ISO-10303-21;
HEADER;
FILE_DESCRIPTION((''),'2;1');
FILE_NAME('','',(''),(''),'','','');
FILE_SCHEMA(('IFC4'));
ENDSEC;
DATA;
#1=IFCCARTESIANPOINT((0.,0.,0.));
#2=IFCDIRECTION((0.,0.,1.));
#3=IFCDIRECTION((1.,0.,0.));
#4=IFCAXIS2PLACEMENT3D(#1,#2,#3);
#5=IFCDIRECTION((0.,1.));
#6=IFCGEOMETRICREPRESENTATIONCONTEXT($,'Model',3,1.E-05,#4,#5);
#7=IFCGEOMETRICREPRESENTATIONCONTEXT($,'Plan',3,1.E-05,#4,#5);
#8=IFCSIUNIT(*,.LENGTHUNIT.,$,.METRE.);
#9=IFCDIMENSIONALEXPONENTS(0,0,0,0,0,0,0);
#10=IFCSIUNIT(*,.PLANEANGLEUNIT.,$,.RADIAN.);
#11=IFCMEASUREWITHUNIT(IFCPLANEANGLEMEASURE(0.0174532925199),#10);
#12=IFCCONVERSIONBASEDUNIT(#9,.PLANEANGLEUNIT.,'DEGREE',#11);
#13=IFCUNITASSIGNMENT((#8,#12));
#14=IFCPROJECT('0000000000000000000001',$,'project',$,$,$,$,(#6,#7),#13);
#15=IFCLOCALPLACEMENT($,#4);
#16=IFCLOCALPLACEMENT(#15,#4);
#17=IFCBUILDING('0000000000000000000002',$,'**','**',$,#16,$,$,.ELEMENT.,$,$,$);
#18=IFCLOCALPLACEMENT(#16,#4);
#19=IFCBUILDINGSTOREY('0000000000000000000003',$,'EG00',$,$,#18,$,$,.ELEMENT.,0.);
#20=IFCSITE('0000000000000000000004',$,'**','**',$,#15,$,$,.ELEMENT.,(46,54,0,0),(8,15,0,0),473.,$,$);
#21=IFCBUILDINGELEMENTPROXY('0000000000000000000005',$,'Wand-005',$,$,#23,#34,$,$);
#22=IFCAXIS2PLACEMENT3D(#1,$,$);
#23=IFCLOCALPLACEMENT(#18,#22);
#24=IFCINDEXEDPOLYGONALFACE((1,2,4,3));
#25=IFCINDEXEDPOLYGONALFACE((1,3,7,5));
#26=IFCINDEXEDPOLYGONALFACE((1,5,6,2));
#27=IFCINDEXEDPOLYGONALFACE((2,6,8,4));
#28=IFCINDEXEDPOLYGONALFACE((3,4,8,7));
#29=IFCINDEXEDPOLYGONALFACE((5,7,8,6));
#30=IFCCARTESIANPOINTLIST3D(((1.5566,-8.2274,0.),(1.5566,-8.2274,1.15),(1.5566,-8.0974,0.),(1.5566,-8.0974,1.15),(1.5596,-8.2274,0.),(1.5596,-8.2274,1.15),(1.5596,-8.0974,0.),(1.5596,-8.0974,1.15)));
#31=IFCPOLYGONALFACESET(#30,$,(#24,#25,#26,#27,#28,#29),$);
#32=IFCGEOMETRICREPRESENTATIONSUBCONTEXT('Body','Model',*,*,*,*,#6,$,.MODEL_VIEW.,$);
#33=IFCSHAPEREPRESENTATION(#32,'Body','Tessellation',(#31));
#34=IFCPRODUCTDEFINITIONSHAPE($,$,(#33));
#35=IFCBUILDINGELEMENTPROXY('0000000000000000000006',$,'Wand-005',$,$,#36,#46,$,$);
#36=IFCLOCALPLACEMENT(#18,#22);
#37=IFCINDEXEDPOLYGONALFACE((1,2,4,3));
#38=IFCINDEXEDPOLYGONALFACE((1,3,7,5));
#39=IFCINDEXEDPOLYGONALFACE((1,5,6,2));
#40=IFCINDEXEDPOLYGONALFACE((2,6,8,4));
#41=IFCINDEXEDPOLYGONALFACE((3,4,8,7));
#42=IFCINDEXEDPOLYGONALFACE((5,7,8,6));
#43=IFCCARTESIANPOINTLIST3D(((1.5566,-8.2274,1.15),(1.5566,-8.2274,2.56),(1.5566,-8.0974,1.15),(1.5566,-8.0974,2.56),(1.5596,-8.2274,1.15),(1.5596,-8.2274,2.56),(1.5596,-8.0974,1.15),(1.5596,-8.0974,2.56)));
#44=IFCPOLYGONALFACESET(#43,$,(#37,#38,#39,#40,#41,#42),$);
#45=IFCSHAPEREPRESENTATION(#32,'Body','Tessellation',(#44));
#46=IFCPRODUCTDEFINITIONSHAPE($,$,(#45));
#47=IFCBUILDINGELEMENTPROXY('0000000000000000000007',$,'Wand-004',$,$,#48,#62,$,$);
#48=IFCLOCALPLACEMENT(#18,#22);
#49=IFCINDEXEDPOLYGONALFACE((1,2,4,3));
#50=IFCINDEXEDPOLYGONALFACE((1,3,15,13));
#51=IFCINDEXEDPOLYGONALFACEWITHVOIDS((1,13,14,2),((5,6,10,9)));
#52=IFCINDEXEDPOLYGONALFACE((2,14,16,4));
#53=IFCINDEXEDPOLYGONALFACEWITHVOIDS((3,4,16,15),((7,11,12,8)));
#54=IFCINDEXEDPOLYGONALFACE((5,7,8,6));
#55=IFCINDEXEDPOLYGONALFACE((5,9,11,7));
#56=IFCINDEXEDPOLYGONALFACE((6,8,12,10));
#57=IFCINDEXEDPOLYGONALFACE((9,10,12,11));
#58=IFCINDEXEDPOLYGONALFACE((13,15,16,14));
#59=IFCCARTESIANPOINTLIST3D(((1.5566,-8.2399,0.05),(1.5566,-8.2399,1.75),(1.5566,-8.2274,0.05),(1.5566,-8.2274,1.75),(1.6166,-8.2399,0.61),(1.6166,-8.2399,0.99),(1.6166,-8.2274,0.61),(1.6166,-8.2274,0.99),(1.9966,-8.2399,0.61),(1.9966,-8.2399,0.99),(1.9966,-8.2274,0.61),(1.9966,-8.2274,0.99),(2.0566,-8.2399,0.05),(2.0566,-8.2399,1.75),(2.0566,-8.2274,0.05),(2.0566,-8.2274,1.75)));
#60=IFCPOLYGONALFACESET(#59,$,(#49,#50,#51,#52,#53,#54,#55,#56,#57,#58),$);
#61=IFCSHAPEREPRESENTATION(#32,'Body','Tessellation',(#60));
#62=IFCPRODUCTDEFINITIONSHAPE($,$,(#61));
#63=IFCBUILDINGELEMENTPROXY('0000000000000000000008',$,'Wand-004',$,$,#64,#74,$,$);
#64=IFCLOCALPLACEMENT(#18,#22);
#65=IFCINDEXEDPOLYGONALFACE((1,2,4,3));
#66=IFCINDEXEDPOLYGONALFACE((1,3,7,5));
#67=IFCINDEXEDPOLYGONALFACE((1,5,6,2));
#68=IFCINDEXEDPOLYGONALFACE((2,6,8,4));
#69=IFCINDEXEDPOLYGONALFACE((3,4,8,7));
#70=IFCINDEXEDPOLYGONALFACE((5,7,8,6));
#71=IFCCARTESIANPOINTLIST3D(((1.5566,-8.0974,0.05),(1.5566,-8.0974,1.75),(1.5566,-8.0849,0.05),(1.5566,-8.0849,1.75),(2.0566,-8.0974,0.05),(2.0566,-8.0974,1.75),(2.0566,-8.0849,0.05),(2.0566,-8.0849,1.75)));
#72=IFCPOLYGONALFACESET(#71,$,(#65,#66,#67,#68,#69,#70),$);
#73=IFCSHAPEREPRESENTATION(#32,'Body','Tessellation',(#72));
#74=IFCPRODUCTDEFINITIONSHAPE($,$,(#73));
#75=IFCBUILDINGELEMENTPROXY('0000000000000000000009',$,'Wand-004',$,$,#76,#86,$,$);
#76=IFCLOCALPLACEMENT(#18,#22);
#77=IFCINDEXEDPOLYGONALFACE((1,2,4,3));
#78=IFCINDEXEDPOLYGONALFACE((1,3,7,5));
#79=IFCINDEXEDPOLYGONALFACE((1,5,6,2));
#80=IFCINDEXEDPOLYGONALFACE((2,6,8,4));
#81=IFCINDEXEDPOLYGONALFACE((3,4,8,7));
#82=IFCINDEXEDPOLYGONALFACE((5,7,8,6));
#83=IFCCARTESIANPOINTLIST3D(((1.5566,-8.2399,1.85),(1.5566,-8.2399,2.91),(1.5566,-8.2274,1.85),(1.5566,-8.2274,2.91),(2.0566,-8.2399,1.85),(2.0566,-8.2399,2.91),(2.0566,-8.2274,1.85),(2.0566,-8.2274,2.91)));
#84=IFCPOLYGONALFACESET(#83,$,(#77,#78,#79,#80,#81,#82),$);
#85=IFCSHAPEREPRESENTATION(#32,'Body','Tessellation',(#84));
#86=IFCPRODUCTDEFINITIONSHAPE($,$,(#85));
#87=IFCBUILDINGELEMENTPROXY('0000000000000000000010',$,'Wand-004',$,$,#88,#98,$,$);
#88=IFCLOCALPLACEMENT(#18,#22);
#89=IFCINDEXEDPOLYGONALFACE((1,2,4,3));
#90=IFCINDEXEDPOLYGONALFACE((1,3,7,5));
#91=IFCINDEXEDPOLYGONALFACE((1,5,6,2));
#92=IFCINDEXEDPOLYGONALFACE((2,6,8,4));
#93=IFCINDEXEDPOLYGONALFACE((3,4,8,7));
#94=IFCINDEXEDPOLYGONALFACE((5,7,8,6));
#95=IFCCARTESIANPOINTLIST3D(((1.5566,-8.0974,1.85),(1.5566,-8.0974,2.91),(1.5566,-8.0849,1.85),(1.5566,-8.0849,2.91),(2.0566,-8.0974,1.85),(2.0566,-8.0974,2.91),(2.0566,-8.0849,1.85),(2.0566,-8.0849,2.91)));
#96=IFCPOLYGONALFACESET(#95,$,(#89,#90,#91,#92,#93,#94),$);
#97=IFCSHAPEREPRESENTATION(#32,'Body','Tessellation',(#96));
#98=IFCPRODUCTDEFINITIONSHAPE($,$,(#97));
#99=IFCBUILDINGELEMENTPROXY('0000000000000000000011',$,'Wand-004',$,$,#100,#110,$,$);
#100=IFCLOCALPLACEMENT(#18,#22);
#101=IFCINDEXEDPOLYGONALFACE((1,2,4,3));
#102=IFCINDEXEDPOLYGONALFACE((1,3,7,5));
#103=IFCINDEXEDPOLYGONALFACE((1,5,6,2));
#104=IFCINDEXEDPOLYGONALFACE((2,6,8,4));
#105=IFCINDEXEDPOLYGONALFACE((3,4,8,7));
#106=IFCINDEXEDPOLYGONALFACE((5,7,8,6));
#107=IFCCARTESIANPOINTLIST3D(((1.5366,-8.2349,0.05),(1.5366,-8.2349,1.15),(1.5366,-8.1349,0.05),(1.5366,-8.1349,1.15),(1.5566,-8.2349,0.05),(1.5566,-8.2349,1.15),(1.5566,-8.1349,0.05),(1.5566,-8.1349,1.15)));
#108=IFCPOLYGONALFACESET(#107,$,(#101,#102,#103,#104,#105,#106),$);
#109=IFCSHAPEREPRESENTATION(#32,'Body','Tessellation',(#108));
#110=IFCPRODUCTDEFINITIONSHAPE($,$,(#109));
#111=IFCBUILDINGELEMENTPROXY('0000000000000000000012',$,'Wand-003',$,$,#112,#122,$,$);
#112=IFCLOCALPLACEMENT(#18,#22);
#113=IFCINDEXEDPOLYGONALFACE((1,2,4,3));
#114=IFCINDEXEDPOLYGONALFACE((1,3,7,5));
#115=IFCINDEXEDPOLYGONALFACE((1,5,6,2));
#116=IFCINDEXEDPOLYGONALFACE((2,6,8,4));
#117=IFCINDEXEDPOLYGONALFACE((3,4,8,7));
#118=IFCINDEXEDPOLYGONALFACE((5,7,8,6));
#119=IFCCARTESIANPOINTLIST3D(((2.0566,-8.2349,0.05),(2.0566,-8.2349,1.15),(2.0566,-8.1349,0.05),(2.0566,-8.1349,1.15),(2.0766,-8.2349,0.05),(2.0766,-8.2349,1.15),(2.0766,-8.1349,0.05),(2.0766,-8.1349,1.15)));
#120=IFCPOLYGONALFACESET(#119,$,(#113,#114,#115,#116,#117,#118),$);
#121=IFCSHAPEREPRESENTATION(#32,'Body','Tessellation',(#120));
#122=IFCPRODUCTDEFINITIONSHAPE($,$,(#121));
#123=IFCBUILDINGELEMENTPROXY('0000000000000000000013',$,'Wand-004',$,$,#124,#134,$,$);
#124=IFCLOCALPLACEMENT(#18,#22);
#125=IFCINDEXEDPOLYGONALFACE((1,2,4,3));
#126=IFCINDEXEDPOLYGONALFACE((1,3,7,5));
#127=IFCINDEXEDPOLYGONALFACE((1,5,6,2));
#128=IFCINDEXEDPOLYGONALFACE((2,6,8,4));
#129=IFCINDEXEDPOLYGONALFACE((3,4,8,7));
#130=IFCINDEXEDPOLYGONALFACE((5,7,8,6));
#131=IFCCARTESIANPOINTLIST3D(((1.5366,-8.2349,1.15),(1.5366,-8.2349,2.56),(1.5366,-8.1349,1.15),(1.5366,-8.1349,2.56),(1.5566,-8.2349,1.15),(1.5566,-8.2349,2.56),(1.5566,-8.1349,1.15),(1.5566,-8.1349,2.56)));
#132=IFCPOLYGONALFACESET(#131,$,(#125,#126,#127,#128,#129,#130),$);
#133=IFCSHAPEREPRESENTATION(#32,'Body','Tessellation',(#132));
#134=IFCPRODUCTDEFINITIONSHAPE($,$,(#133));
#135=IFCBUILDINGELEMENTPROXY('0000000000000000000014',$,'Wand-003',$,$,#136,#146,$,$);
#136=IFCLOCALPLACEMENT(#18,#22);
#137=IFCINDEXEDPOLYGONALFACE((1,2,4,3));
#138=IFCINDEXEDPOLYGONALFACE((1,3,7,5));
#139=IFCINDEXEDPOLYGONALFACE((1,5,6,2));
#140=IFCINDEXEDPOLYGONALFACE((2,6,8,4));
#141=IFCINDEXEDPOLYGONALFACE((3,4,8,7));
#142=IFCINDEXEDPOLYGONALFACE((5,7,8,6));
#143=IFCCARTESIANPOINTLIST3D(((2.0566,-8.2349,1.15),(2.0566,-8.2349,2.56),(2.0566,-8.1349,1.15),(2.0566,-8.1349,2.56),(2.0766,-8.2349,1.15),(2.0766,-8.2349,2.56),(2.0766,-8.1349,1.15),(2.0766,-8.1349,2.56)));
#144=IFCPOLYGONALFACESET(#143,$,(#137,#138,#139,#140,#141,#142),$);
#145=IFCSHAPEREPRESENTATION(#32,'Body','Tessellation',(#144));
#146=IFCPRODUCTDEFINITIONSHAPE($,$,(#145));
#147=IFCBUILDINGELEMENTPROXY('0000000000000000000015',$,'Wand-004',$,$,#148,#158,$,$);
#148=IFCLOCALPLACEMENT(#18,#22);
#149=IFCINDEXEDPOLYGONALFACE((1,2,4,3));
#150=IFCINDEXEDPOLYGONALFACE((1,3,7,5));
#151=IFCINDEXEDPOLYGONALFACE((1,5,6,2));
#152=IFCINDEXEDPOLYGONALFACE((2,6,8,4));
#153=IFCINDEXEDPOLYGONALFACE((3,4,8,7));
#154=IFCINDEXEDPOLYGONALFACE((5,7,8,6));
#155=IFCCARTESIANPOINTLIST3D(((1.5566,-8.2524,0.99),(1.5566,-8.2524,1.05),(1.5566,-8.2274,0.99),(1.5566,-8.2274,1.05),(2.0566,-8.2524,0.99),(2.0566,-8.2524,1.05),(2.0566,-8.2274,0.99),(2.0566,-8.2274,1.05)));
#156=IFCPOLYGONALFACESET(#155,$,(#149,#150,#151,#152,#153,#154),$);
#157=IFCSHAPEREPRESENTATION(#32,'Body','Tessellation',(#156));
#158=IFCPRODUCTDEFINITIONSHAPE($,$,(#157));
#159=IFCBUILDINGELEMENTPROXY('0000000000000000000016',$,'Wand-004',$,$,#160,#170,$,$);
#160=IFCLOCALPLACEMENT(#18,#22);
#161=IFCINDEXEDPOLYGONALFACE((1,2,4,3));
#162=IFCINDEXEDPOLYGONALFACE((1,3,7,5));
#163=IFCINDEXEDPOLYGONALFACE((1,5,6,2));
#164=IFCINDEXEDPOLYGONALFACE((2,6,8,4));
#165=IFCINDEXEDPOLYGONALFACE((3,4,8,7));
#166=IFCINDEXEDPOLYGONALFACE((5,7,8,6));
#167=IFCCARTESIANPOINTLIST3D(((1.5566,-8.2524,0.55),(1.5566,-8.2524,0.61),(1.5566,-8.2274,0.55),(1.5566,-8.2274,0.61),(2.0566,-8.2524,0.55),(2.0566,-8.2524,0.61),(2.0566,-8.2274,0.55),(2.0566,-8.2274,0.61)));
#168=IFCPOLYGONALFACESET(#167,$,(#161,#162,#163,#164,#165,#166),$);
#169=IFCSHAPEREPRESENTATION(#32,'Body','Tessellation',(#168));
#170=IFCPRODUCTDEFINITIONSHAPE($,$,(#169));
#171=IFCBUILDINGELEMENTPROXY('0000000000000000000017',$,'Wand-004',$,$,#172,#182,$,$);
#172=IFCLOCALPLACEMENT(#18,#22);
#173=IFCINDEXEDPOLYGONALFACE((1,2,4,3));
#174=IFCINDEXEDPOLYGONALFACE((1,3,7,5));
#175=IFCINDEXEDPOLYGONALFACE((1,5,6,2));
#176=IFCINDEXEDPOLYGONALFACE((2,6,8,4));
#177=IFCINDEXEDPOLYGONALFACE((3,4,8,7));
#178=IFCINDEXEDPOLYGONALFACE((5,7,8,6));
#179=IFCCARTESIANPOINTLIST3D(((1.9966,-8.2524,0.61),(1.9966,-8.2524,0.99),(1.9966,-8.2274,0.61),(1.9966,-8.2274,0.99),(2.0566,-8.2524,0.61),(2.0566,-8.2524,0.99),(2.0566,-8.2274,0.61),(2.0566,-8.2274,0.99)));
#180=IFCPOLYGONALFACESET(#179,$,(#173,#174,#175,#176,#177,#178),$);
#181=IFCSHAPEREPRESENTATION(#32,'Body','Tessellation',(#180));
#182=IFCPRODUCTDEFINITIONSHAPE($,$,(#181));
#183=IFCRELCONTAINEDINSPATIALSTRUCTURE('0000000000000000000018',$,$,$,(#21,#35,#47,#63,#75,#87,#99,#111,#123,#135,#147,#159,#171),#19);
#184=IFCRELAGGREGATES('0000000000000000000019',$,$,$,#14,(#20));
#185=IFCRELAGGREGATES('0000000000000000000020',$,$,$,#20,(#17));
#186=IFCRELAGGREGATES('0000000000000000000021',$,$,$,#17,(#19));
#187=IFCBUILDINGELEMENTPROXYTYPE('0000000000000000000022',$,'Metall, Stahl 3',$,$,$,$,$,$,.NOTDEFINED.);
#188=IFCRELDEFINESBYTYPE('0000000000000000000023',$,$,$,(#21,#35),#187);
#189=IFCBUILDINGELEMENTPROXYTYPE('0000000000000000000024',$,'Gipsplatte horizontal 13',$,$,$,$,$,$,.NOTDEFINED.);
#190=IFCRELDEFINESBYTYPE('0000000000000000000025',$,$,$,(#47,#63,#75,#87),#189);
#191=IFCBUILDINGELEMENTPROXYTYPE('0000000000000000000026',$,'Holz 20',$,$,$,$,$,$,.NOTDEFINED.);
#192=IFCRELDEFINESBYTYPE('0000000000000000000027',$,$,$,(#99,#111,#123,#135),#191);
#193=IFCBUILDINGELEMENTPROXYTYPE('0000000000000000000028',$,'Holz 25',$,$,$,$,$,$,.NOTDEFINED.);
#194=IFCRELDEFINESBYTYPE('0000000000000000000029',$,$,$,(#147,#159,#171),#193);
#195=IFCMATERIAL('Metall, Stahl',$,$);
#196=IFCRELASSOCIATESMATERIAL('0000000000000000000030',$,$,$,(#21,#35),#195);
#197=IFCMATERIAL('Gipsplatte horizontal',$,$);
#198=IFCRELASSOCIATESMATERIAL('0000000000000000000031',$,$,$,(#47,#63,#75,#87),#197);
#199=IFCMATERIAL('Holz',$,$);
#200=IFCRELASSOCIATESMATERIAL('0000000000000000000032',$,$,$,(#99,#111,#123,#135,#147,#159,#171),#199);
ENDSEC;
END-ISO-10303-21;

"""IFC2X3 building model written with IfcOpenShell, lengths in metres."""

from ifc_helpers import new_model, entity, si_unit, converted_unit, direction, frame, origin_with_axes, origin_2d_with_axis, place, context, subcontext, project, spatial, polyline, rectangle, outline, extrude, material, type_object, element, save


model = new_model("IFC2X3")

# Units and contexts
model_context = context("Model", 3, precision=1e-05, world=origin_with_axes(), true_north=direction((0.0, 1.0)))
plan_context = context("Plan", 3, precision=1e-05, world=origin_with_axes(), true_north=direction((0.0, 1.0)))
body_context = subcontext(model_context, "Body", "Model", "MODEL_VIEW")
ifc_project = project(units=[si_unit("LENGTHUNIT", "METRE"), converted_unit("PLANEANGLEUNIT", "DEGREE", entity("IfcPlaneAngleMeasure", 0.0174532925199), si_unit("PLANEANGLEUNIT", "RADIAN"), dimensions=[0, 0, 0, 0, 0, 0, 0])], contexts=[model_context, plan_context])

# Site, building, storey
site_placement = place(None, origin_with_axes())
site = spatial("IfcSite", under=ifc_project, at=site_placement, Name="**", Description="**", CompositionType="ELEMENT", RefLatitude=(46, 54, 0, 0), RefLongitude=(8, 15, 0, 0), RefElevation=473.0)
building_placement = place(site_placement, origin_with_axes())
building = spatial("IfcBuilding", under=site, at=building_placement, Name="**", Description="**", CompositionType="ELEMENT")
storey_placement = place(building_placement, origin_with_axes())
storey = spatial("IfcBuildingStorey", under=building, at=storey_placement, Name="EG00", CompositionType="ELEMENT", Elevation=0.0)

# Building element proxies
ifc_material_1 = material(Name="Metall, Stahl")
building_element_proxy_type_1 = type_object("IfcBuildingElementProxyType", Name="Metall, Stahl 3", PredefinedType="NOTDEFINED")
proxy_1_placement = place(storey_placement, frame((1.5566, -8.0974, 0.0), z_axis=(0.0, 0.0, 1.0), x_axis=(0.0, -1.0, 0.0)))
element("IfcBuildingElementProxy", 1, at=proxy_1_placement, inside=storey, type_object=building_element_proxy_type_1, material=ifc_material_1, Name="Wand-005", context=body_context, shape_type="SweptSolid", body=[
    extrude(outline(polyline([(0.0, 0.0), (0.13, 0.0), (0.13, 0.003), (0.0, 0.003), (0.0, 0.0)])), origin_with_axes(), (0.0, 0.0, 1.0), 1.15),
])
proxy_2_placement = place(storey_placement, frame((1.5566, -8.0974, 1.15), z_axis=(0.0, 0.0, 1.0), x_axis=(0.0, -1.0, 0.0)))
element("IfcBuildingElementProxy", 2, at=proxy_2_placement, inside=storey, type_object=building_element_proxy_type_1, material=ifc_material_1, Name="Wand-005", context=body_context, shape_type="SweptSolid", body=[
    extrude(outline(polyline([(0.0, 0.0), (0.13, 0.0), (0.13, 0.003), (0.0, 0.003), (0.0, 0.0)])), origin_with_axes(), (0.0, 0.0, 1.0), 1.41),
])

# Building element proxy, opening
ifc_material_2 = material(Name="Gipsplatte horizontal")
building_element_proxy_type_2 = type_object("IfcBuildingElementProxyType", Name="Gipsplatte horizontal 13", PredefinedType="NOTDEFINED")
proxy_3_placement = place(storey_placement, frame((1.5566, -8.2399, 0.05), z_axis=(0.0, 0.0, 1.0), x_axis=(1.0, 0.0, 0.0)))
proxy_3 = element("IfcBuildingElementProxy", 3, at=proxy_3_placement, inside=storey, type_object=building_element_proxy_type_2, material=ifc_material_2, Name="Wand-004", context=body_context, shape_type="SweptSolid", body=[
    extrude(outline(polyline([(0.0, 0.0), (0.5, 0.0), (0.5, 0.0125), (0.0, 0.0125), (0.0, 0.0)])), origin_with_axes(), (0.0, 0.0, 1.0), 1.7),
])
opening_placement = place(proxy_3_placement, frame((-1.5566, 8.2399, -0.05), z_axis=(0.0, 0.0, 1.0), x_axis=(1.0, 0.0, 0.0)))
element("IfcOpeningElement", 4, at=opening_placement, cuts=proxy_3, context=body_context, shape_type="SweptSolid", body=[
    extrude(rectangle(XDim=0.38, YDim=0.38, at=origin_2d_with_axis()), frame((1.8066, -8.2524, 0.8), z_axis=(0.0, -1.0, 0.0), x_axis=(1.0, 0.0, 0.0)), (0.0, 0.0, -1.0), 0.0375),
])

# Building element proxies
proxy_4_placement = place(storey_placement, frame((1.5566, -8.0849, 0.05), z_axis=(0.0, 0.0, 1.0), x_axis=(1.0, 0.0, 0.0)))
element("IfcBuildingElementProxy", 5, at=proxy_4_placement, inside=storey, type_object=building_element_proxy_type_2, material=ifc_material_2, Name="Wand-004", context=body_context, shape_type="SweptSolid", body=[
    extrude(outline(polyline([(0.0, -0.0125), (0.5, -0.0125), (0.5, 0.0), (0.0, 0.0), (0.0, -0.0125)])), origin_with_axes(), (0.0, 0.0, 1.0), 1.7),
])
proxy_5_placement = place(storey_placement, frame((1.5566, -8.2399, 1.85), z_axis=(0.0, 0.0, 1.0), x_axis=(1.0, 0.0, 0.0)))
element("IfcBuildingElementProxy", 6, at=proxy_5_placement, inside=storey, type_object=building_element_proxy_type_2, material=ifc_material_2, Name="Wand-004", context=body_context, shape_type="SweptSolid", body=[
    extrude(outline(polyline([(0.0, 0.0), (0.5, 0.0), (0.5, 0.0125), (0.0, 0.0125), (0.0, 0.0)])), origin_with_axes(), (0.0, 0.0, 1.0), 1.06),
])
proxy_6_placement = place(storey_placement, frame((1.5566, -8.0849, 1.85), z_axis=(0.0, 0.0, 1.0), x_axis=(1.0, 0.0, 0.0)))
element("IfcBuildingElementProxy", 7, at=proxy_6_placement, inside=storey, type_object=building_element_proxy_type_2, material=ifc_material_2, Name="Wand-004", context=body_context, shape_type="SweptSolid", body=[
    extrude(outline(polyline([(0.0, -0.0125), (0.5, -0.0125), (0.5, 0.0), (0.0, 0.0), (0.0, -0.0125)])), origin_with_axes(), (0.0, 0.0, 1.0), 1.06),
])
ifc_material_3 = material(Name="Holz")
building_element_proxy_type_3 = type_object("IfcBuildingElementProxyType", Name="Holz 20", PredefinedType="NOTDEFINED")
proxy_7_placement = place(storey_placement, frame((1.5366, -8.1349, 0.05), z_axis=(0.0, 0.0, 1.0), x_axis=(0.0, -1.0, 0.0)))
element("IfcBuildingElementProxy", 8, at=proxy_7_placement, inside=storey, type_object=building_element_proxy_type_3, material=ifc_material_3, Name="Wand-004", context=body_context, shape_type="SweptSolid", body=[
    extrude(outline(polyline([(0.0, 0.0), (0.1, 0.0), (0.1, 0.02), (0.0, 0.02), (0.0, 0.0)])), origin_with_axes(), (0.0, 0.0, 1.0), 1.1),
])
proxy_8_placement = place(storey_placement, frame((2.0766, -8.1349, 0.05), z_axis=(0.0, 0.0, 1.0), x_axis=(0.0, -1.0, 0.0)))
element("IfcBuildingElementProxy", 9, at=proxy_8_placement, inside=storey, type_object=building_element_proxy_type_3, material=ifc_material_3, Name="Wand-003", context=body_context, shape_type="SweptSolid", body=[
    extrude(outline(polyline([(0.0, -0.02), (0.1, -0.02), (0.1, 0.0), (0.0, 0.0), (0.0, -0.02)])), origin_with_axes(), (0.0, 0.0, 1.0), 1.1),
])
proxy_9_placement = place(storey_placement, frame((1.5366, -8.1349, 1.15), z_axis=(0.0, 0.0, 1.0), x_axis=(0.0, -1.0, 0.0)))
element("IfcBuildingElementProxy", 10, at=proxy_9_placement, inside=storey, type_object=building_element_proxy_type_3, material=ifc_material_3, Name="Wand-004", context=body_context, shape_type="SweptSolid", body=[
    extrude(outline(polyline([(0.0, 0.0), (0.1, 0.0), (0.1, 0.02), (0.0, 0.02), (0.0, 0.0)])), origin_with_axes(), (0.0, 0.0, 1.0), 1.41),
])
proxy_10_placement = place(storey_placement, frame((2.0766, -8.1349, 1.15), z_axis=(0.0, 0.0, 1.0), x_axis=(0.0, -1.0, 0.0)))
element("IfcBuildingElementProxy", 11, at=proxy_10_placement, inside=storey, type_object=building_element_proxy_type_3, material=ifc_material_3, Name="Wand-003", context=body_context, shape_type="SweptSolid", body=[
    extrude(outline(polyline([(0.0, -0.02), (0.1, -0.02), (0.1, 0.0), (0.0, 0.0), (0.0, -0.02)])), origin_with_axes(), (0.0, 0.0, 1.0), 1.41),
])
building_element_proxy_type_4 = type_object("IfcBuildingElementProxyType", Name="Holz 25", PredefinedType="NOTDEFINED")
for number, where, z_axis, x_axis, name in (
    (12, (2.0566, -8.2274, 0.99), (0.0, 0.0, 1.0), (-1.0, 0.0, 0.0), "Wand-004"),
    (13, (2.0566, -8.2274, 0.55), (0.0, 0.0, 1.0), (-1.0, 0.0, 0.0), "Wand-004"),
):
    element("IfcBuildingElementProxy", number, at=place(storey_placement, frame(where, z_axis=z_axis, x_axis=x_axis)), inside=storey, type_object=building_element_proxy_type_4, material=ifc_material_3, Name=name, context=body_context, shape_type="SweptSolid", body=[
        extrude(outline(polyline([(0.0, 0.0), (0.5, 0.0), (0.5, 0.025), (0.0, 0.025), (0.0, 0.0)])), origin_with_axes(), (0.0, 0.0, 1.0), 0.06),
    ])
for number, where, z_axis, x_axis, name in (
    (14, (1.9966, -8.2524, 0.61), (0.0, 0.0, 1.0), (1.0, 0.0, 0.0), "Wand-004"),
):
    element("IfcBuildingElementProxy", number, at=place(storey_placement, frame(where, z_axis=z_axis, x_axis=x_axis)), inside=storey, type_object=building_element_proxy_type_4, material=ifc_material_3, Name=name, context=body_context, shape_type="SweptSolid", body=[
        extrude(outline(polyline([(0.0, 0.0), (0.06, 0.0), (0.06, 0.025), (0.0, 0.025), (0.0, 0.0)])), origin_with_axes(), (0.0, 0.0, 1.0), 0.38),
    ])

save(model, "model.ifc")
